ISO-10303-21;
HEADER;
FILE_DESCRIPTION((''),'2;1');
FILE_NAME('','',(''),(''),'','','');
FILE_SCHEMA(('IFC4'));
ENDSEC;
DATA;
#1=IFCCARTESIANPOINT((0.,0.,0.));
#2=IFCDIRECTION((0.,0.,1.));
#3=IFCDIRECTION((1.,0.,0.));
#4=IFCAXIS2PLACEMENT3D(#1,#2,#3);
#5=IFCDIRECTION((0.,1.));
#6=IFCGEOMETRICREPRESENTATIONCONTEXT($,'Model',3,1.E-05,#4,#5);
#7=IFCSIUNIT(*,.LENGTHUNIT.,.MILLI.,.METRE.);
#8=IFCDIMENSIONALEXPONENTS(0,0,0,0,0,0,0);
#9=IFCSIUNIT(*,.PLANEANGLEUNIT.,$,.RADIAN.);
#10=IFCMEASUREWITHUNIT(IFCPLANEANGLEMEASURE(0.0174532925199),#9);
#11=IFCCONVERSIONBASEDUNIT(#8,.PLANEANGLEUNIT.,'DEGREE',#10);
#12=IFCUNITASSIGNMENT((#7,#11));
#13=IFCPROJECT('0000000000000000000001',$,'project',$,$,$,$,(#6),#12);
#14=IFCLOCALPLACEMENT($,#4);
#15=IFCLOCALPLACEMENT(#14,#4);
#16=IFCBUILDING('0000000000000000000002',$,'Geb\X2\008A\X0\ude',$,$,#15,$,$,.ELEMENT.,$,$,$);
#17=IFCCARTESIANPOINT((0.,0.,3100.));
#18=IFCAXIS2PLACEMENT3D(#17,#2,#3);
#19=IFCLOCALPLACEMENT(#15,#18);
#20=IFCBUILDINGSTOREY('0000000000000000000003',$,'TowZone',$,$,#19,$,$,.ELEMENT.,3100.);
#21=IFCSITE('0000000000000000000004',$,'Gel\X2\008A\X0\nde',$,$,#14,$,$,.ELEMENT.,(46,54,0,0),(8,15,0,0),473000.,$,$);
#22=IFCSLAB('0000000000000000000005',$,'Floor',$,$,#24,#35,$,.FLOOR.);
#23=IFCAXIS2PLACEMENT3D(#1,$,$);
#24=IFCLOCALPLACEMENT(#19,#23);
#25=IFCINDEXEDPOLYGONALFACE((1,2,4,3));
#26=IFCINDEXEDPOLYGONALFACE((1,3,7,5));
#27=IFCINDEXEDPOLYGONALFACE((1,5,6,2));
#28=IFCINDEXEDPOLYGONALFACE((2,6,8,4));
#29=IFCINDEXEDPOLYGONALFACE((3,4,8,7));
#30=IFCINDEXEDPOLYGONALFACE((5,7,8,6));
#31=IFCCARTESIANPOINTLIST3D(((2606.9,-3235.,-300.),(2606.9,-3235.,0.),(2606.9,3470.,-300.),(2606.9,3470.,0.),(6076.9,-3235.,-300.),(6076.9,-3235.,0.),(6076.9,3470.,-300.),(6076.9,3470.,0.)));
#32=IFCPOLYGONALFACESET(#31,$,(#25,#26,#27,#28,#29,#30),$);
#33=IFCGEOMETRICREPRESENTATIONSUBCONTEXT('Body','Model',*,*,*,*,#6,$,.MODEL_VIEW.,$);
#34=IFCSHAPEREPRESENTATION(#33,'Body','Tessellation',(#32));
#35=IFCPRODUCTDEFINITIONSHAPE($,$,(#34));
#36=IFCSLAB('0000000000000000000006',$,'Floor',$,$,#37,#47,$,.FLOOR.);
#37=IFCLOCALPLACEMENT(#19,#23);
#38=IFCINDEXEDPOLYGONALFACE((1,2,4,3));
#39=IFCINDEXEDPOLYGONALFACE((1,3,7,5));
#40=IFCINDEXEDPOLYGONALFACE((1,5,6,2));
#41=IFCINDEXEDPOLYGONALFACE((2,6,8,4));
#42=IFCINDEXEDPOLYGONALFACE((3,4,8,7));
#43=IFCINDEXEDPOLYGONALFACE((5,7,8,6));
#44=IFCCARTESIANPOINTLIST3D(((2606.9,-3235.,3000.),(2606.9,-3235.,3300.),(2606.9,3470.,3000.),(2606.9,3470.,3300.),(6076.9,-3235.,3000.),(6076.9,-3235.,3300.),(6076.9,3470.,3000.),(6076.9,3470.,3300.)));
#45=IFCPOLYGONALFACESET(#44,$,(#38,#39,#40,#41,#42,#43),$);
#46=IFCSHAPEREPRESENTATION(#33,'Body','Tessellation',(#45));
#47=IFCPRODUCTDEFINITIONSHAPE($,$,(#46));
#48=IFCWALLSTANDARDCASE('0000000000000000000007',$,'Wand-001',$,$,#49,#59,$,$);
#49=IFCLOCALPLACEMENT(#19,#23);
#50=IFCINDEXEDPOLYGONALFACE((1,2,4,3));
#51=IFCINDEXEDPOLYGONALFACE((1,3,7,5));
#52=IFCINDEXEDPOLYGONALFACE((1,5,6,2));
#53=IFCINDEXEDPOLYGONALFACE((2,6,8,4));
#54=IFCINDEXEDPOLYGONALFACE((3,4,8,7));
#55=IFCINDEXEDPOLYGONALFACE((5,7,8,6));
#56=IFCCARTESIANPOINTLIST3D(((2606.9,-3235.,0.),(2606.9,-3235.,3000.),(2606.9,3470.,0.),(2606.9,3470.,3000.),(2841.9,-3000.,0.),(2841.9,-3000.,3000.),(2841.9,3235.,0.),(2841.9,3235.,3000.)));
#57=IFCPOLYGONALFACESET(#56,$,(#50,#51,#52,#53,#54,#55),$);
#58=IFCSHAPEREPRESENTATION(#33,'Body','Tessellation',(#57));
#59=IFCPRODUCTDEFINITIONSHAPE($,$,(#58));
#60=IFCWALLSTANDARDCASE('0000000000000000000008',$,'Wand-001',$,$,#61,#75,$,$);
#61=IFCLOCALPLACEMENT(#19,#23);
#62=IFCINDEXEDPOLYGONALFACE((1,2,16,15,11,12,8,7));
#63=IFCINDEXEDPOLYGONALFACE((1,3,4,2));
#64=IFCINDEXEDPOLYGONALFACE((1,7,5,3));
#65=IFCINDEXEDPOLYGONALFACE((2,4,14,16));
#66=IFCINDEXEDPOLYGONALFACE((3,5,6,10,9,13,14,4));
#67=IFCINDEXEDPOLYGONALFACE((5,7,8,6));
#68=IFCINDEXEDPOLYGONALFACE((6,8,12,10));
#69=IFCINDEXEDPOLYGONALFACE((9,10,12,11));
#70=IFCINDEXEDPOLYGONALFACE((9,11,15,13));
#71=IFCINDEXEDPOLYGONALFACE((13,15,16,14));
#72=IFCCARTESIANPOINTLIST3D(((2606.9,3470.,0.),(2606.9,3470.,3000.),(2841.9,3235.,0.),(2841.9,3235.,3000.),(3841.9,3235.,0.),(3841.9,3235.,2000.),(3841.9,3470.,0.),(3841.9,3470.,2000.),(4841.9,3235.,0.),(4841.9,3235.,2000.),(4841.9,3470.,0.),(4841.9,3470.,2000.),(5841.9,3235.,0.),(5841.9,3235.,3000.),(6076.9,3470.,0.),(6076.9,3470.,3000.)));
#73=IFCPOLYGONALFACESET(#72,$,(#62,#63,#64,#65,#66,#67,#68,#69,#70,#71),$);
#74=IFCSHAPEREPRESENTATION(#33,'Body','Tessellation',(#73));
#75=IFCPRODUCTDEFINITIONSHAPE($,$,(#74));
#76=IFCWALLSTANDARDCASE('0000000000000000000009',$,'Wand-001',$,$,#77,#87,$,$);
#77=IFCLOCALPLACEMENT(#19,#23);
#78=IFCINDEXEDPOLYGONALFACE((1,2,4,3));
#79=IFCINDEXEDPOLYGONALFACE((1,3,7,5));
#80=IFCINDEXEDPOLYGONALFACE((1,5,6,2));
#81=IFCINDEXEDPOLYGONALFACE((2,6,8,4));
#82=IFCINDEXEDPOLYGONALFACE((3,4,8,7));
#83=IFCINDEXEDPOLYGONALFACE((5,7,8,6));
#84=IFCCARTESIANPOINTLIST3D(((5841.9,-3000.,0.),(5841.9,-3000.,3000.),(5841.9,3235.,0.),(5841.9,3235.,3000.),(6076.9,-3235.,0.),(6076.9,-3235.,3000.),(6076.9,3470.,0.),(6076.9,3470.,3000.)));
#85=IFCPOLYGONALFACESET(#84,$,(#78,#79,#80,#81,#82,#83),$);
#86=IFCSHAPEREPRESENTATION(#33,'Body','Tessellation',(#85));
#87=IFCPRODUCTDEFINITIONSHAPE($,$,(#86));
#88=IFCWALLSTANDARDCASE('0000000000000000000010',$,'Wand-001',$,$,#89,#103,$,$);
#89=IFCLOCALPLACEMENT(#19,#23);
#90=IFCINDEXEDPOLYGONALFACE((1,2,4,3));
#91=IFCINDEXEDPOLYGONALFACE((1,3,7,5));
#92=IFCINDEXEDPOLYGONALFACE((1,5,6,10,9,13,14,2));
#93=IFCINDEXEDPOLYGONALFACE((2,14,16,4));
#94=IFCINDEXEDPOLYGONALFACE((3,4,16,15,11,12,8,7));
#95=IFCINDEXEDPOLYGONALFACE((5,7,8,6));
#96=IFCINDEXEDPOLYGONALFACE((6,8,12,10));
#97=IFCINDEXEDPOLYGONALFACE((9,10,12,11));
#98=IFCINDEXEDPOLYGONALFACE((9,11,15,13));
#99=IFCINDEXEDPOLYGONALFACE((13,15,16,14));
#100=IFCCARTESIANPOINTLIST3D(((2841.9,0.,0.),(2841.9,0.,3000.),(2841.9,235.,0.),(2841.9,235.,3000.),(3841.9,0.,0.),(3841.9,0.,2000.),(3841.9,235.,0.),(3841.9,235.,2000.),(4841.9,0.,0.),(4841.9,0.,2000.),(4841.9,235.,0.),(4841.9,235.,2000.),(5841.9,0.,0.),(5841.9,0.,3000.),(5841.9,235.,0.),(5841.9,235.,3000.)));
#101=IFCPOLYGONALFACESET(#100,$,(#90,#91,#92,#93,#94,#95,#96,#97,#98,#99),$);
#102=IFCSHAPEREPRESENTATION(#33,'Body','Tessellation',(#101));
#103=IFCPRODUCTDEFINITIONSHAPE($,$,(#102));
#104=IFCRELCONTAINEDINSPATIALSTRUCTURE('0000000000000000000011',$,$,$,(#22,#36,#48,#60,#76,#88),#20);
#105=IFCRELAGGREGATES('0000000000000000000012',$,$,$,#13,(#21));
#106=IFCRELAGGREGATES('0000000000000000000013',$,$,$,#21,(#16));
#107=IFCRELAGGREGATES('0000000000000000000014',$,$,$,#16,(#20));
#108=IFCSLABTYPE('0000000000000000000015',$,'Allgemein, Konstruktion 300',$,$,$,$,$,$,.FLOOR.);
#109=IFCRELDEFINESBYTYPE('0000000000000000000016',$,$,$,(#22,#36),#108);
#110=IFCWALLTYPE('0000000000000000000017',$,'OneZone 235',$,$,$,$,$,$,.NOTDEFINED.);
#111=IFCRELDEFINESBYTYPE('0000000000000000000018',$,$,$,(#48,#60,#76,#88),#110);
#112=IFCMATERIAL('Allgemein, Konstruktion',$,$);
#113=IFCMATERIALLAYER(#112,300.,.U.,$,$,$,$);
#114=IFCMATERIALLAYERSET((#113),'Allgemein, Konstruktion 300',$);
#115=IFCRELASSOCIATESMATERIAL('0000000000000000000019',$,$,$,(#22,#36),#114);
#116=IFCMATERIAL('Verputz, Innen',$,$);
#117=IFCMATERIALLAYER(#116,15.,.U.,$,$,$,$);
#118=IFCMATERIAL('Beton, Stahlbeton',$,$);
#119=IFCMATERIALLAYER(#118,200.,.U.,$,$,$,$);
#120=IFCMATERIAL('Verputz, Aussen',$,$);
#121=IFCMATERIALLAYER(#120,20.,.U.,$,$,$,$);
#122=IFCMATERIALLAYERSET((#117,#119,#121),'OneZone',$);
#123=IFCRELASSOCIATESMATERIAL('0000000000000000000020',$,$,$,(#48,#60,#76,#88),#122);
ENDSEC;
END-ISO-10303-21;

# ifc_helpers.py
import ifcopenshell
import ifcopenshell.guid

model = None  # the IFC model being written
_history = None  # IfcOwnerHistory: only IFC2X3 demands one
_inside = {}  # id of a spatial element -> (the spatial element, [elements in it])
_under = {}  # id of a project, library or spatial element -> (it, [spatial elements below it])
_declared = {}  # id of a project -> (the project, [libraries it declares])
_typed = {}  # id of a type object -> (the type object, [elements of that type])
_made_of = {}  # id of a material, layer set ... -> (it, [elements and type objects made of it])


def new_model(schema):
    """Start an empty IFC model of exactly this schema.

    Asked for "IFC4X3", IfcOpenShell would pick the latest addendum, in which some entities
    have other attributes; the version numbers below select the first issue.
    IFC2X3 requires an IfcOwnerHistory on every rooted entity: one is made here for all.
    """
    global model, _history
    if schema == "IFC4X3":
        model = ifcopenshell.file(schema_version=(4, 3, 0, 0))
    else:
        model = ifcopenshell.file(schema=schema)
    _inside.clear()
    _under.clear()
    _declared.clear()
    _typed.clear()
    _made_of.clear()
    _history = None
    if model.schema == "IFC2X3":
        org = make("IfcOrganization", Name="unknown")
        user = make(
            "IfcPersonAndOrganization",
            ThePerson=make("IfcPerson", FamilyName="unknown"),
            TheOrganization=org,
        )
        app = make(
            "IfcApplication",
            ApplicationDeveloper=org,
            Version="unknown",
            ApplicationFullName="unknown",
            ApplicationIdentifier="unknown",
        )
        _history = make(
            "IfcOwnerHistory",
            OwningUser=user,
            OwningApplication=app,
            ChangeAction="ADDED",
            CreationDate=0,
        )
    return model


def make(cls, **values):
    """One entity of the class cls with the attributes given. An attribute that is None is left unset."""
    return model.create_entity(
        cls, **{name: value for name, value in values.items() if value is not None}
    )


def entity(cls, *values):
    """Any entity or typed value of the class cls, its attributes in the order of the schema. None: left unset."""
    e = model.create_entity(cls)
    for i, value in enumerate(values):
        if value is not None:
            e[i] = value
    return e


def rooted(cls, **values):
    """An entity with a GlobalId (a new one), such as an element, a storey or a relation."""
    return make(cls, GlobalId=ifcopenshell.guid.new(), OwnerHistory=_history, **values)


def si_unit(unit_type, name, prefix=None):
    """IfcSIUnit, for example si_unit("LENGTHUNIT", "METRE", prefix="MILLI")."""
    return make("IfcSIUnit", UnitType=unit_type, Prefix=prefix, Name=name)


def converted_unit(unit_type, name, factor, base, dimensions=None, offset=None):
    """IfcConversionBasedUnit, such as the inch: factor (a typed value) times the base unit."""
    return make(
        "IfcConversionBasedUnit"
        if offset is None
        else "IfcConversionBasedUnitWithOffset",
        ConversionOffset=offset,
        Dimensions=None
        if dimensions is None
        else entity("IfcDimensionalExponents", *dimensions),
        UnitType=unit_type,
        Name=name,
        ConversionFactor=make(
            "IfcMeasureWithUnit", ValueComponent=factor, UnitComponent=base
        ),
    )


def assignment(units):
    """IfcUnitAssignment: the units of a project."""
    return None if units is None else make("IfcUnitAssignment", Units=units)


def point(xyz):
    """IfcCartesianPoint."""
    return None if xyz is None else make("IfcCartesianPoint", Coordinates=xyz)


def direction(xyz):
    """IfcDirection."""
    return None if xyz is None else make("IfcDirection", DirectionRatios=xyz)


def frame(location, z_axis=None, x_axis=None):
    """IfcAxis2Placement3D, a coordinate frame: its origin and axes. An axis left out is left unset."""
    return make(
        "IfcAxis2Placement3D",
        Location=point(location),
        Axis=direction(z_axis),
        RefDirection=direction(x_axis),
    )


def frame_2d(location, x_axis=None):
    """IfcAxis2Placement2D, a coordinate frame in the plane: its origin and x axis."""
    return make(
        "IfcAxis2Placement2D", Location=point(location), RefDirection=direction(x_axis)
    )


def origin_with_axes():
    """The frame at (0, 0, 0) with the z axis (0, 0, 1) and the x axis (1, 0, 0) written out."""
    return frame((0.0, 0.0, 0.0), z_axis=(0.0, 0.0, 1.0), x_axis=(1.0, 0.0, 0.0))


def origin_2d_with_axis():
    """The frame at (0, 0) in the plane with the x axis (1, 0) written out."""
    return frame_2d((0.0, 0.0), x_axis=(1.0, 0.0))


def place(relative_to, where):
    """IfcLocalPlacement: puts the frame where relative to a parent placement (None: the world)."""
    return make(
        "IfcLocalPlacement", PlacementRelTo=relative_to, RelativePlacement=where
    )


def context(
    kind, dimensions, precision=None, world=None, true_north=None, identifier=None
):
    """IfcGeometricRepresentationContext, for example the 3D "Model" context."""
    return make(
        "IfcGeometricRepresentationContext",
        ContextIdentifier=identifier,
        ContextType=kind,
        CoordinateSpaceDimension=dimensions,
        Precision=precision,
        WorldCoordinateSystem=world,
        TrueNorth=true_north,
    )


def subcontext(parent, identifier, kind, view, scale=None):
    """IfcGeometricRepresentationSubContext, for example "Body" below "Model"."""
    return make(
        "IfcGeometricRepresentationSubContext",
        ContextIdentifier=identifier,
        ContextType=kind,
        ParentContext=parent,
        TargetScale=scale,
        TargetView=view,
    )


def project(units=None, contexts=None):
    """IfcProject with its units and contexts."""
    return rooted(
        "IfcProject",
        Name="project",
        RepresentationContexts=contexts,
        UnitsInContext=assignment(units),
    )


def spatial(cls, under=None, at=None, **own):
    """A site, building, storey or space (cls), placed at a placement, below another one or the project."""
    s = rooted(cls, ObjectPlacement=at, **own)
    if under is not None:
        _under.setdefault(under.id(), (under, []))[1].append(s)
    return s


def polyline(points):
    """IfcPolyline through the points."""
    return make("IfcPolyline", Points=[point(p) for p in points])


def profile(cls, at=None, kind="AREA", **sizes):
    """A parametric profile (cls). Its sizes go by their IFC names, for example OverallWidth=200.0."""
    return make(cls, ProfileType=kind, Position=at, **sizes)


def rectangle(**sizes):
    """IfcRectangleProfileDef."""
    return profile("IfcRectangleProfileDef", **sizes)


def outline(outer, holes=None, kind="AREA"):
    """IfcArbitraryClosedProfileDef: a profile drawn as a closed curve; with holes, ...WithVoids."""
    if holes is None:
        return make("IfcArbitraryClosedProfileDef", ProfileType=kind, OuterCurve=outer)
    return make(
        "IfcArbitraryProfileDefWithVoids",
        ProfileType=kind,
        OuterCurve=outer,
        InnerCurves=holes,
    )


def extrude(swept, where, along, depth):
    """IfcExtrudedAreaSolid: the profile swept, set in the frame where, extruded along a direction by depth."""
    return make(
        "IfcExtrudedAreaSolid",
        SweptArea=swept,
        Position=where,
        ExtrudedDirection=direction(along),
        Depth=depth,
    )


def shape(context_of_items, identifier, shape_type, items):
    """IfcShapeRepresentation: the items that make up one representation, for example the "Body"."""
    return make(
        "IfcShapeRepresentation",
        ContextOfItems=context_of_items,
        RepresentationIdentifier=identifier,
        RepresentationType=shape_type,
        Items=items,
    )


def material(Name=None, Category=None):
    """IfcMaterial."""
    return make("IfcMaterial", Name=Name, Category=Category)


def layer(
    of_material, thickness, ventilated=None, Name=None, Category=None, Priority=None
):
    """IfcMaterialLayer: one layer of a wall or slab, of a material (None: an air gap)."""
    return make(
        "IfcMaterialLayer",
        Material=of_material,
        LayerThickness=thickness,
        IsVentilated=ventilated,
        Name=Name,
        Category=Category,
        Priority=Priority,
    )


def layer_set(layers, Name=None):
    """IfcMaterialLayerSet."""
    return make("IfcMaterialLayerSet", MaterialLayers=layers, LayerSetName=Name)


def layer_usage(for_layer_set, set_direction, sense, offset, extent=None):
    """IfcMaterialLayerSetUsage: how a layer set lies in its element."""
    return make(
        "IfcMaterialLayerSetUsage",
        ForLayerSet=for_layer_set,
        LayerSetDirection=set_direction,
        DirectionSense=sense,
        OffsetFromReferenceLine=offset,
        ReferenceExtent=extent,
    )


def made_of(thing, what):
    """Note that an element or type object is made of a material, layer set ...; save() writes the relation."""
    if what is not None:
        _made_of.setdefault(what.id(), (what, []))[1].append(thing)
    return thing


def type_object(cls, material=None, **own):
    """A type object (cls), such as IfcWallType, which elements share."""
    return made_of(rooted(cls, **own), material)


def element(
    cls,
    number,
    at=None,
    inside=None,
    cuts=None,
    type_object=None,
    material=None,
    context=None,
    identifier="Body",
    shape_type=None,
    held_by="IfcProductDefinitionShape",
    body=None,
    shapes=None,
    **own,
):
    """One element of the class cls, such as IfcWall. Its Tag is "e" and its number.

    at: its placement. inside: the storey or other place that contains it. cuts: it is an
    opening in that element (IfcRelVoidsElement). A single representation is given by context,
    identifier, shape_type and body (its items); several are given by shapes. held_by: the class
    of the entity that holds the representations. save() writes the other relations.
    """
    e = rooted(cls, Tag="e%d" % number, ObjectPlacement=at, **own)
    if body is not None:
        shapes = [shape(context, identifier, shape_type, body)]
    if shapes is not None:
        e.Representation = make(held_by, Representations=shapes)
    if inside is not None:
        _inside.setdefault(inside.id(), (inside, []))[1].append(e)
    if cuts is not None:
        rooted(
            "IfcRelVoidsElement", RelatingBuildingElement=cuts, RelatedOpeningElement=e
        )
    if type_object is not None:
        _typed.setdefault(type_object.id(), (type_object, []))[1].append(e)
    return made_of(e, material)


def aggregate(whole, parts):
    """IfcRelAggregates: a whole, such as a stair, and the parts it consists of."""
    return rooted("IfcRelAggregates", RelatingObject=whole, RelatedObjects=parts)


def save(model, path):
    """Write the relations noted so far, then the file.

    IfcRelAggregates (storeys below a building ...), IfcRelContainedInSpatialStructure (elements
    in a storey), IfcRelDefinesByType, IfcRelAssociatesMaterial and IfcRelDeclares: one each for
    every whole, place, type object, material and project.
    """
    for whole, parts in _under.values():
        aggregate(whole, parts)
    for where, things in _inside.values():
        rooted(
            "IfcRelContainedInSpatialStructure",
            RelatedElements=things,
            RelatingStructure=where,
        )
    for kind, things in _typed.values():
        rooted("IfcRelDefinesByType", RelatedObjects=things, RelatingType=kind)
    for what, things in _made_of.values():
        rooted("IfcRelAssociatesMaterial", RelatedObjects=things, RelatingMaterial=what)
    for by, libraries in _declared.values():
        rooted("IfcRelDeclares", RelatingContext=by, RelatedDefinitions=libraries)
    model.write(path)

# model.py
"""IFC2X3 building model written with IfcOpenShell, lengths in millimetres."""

from ifc_helpers import new_model, entity, si_unit, converted_unit, direction, frame, origin_with_axes, origin_2d_with_axis, place, context, subcontext, project, spatial, polyline, rectangle, outline, extrude, material, layer, layer_set, layer_usage, type_object, element, save


model = new_model("IFC2X3")

# Units and contexts
model_context = context("Model", 3, precision=1e-05, world=origin_with_axes(), true_north=direction((0.0, 1.0)))
body_context = subcontext(model_context, "Body", "Model", "MODEL_VIEW")
ifc_project = project(units=[si_unit("LENGTHUNIT", "METRE", prefix="MILLI"), converted_unit("PLANEANGLEUNIT", "DEGREE", entity("IfcPlaneAngleMeasure", 0.0174532925199), si_unit("PLANEANGLEUNIT", "RADIAN"), dimensions=[0, 0, 0, 0, 0, 0, 0])], contexts=[model_context])

# Site, building, storey
site_placement = place(None, origin_with_axes())
site = spatial("IfcSite", under=ifc_project, at=site_placement, Name="Gel\u008ande", CompositionType="ELEMENT", RefLatitude=(46, 54, 0, 0), RefLongitude=(8, 15, 0, 0), RefElevation=473000.0)
building_placement = place(site_placement, origin_with_axes())
building = spatial("IfcBuilding", under=site, at=building_placement, Name="Geb\u008aude", CompositionType="ELEMENT")
storey_placement = place(building_placement, frame((0.0, 0.0, 3100.0), z_axis=(0.0, 0.0, 1.0), x_axis=(1.0, 0.0, 0.0)))
storey = spatial("IfcBuildingStorey", under=building, at=storey_placement, Name="TowZone", CompositionType="ELEMENT", Elevation=3100.0)

# Slabs
ifc_material_1 = material(Name="Allgemein, Konstruktion")
ifc_layer_1 = layer(ifc_material_1, 300.0, ventilated="UNKNOWN")
ifc_layer_set_1 = layer_set([ifc_layer_1], Name="Allgemein, Konstruktion 300")
ifc_layer_usage_1 = layer_usage(ifc_layer_set_1, "AXIS3", "NEGATIVE", 300.0)
slab_type = type_object("IfcSlabType", Name="Allgemein, Konstruktion 300", PredefinedType="FLOOR")
slab_1_placement = place(storey_placement, frame((2606.9, -3235.0, 0.0), z_axis=(0.0, 0.0, 1.0), x_axis=(1.0, 0.0, 0.0)))
element("IfcSlab", 1, at=slab_1_placement, inside=storey, type_object=slab_type, material=ifc_layer_usage_1, Name="Floor", PredefinedType="FLOOR", context=body_context, shape_type="SweptSolid", body=[
    extrude(outline(polyline([(0.0, 0.0), (3470.0, 0.0), (3470.0, 6705.0), (0.0, 6705.0), (0.0, 0.0)])), frame((0.0, 0.0, -300.0), z_axis=(0.0, 0.0, 1.0), x_axis=(1.0, 0.0, 0.0)), (0.0, 0.0, 1.0), 300.0),
])
ifc_layer_usage_2 = layer_usage(ifc_layer_set_1, "AXIS3", "NEGATIVE", 300.0)
slab_2_placement = place(storey_placement, frame((2606.9, -3235.0, 3300.0), z_axis=(0.0, 0.0, 1.0), x_axis=(1.0, 0.0, 0.0)))
element("IfcSlab", 2, at=slab_2_placement, inside=storey, type_object=slab_type, material=ifc_layer_usage_2, Name="Floor", PredefinedType="FLOOR", context=body_context, shape_type="SweptSolid", body=[
    extrude(outline(polyline([(0.0, 0.0), (3470.0, 0.0), (3470.0, 6705.0), (0.0, 6705.0), (0.0, 0.0)])), frame((0.0, 0.0, -300.0), z_axis=(0.0, 0.0, 1.0), x_axis=(1.0, 0.0, 0.0)), (0.0, 0.0, 1.0), 300.0),
])

# Wall
ifc_material_2 = material(Name="Verputz, Innen")
ifc_layer_2 = layer(ifc_material_2, 15.0, ventilated="UNKNOWN")
ifc_material_3 = material(Name="Beton, Stahlbeton")
ifc_layer_3 = layer(ifc_material_3, 200.0, ventilated="UNKNOWN")
ifc_material_4 = material(Name="Verputz, Aussen")
ifc_layer_4 = layer(ifc_material_4, 20.0, ventilated="UNKNOWN")
ifc_layer_set_2 = layer_set([ifc_layer_2, ifc_layer_3, ifc_layer_4], Name="OneZone")
ifc_layer_usage_3 = layer_usage(ifc_layer_set_2, "AXIS2", "NEGATIVE", 0.0)
wall_type = type_object("IfcWallType", Name="OneZone 235", PredefinedType="NOTDEFINED")
wall_1_placement = place(storey_placement, frame((2841.9, 3470.0, 0.0), z_axis=(0.0, 0.0, 1.0), x_axis=(0.0, -1.0, 0.0)))
element("IfcWallStandardCase", 3, at=wall_1_placement, inside=storey, type_object=wall_type, material=ifc_layer_usage_3, Name="Wand-001", context=body_context, shape_type="SweptSolid", body=[
    extrude(outline(polyline([(0.0, -235.0), (6705.0, -235.0), (6470.0, 0.0), (235.0, 0.0), (0.0, -235.0)])), origin_with_axes(), (0.0, 0.0, 1.0), 3000.0),
])

# Wall, opening
ifc_layer_usage_4 = layer_usage(ifc_layer_set_2, "AXIS2", "NEGATIVE", 235.0)
wall_2_placement = place(storey_placement, frame((5841.9, 3470.0, 0.0), z_axis=(0.0, 0.0, 1.0), x_axis=(-1.0, 0.0, 0.0)))
wall_2 = element("IfcWallStandardCase", 4, at=wall_2_placement, inside=storey, type_object=wall_type, material=ifc_layer_usage_4, Name="Wand-001", context=body_context, shape_type="SweptSolid", body=[
    extrude(outline(polyline([(-235.0, 0.0), (3235.0, 0.0), (3000.0, 235.0), (0.0, 235.0), (-235.0, 0.0)])), origin_with_axes(), (0.0, 0.0, 1.0), 3000.0),
])
opening_1_placement = place(wall_2_placement, frame((1500.0, 0.0, 0.0), z_axis=(0.0, 0.0, 1.0), x_axis=(1.0, 0.0, 0.0)))
element("IfcOpeningElement", 5, at=opening_1_placement, cuts=wall_2, context=body_context, shape_type="SweptSolid", body=[
    extrude(rectangle(XDim=1000.0, YDim=2000.0, at=origin_2d_with_axis()), frame((0.0, -235.0, 1000.0), z_axis=(0.0, -1.0, 0.0), x_axis=(-1.0, 0.0, 0.0)), (0.0, 0.0, -1.0), 705.0),
])

# Wall
ifc_layer_usage_5 = layer_usage(ifc_layer_set_2, "AXIS2", "POSITIVE", 0.0)
wall_3_placement = place(storey_placement, frame((5841.9, 3470.0, 0.0), z_axis=(0.0, 0.0, 1.0), x_axis=(0.0, -1.0, 0.0)))
element("IfcWallStandardCase", 6, at=wall_3_placement, inside=storey, type_object=wall_type, material=ifc_layer_usage_5, Name="Wand-001", context=body_context, shape_type="SweptSolid", body=[
    extrude(outline(polyline([(235.0, 0.0), (6470.0, 0.0), (6705.0, 235.0), (0.0, 235.0), (235.0, 0.0)])), origin_with_axes(), (0.0, 0.0, 1.0), 3000.0),
])

# Wall, opening
ifc_layer_usage_6 = layer_usage(ifc_layer_set_2, "AXIS2", "NEGATIVE", 235.0)
wall_4_placement = place(storey_placement, frame((5841.9, 235.0, 0.0), z_axis=(0.0, 0.0, 1.0), x_axis=(-1.0, 0.0, 0.0)))
wall_4 = element("IfcWallStandardCase", 7, at=wall_4_placement, inside=storey, type_object=wall_type, material=ifc_layer_usage_6, Name="Wand-001", context=body_context, shape_type="SweptSolid", body=[
    extrude(outline(polyline([(0.0, 0.0), (3000.0, 0.0), (3000.0, 235.0), (0.0, 235.0), (0.0, 0.0)])), origin_with_axes(), (0.0, 0.0, 1.0), 3000.0),
])
opening_2_placement = place(wall_4_placement, frame((1500.0, 0.0, 0.0), z_axis=(0.0, 0.0, 1.0), x_axis=(1.0, 0.0, 0.0)))
element("IfcOpeningElement", 8, at=opening_2_placement, cuts=wall_4, context=body_context, shape_type="SweptSolid", body=[
    extrude(rectangle(XDim=1000.0, YDim=2000.0, at=origin_2d_with_axis()), frame((0.0, -235.0, 1000.0), z_axis=(0.0, -1.0, 0.0), x_axis=(-1.0, 0.0, 0.0)), (0.0, 0.0, -1.0), 705.0),
])

save(model, "model.ifc")
